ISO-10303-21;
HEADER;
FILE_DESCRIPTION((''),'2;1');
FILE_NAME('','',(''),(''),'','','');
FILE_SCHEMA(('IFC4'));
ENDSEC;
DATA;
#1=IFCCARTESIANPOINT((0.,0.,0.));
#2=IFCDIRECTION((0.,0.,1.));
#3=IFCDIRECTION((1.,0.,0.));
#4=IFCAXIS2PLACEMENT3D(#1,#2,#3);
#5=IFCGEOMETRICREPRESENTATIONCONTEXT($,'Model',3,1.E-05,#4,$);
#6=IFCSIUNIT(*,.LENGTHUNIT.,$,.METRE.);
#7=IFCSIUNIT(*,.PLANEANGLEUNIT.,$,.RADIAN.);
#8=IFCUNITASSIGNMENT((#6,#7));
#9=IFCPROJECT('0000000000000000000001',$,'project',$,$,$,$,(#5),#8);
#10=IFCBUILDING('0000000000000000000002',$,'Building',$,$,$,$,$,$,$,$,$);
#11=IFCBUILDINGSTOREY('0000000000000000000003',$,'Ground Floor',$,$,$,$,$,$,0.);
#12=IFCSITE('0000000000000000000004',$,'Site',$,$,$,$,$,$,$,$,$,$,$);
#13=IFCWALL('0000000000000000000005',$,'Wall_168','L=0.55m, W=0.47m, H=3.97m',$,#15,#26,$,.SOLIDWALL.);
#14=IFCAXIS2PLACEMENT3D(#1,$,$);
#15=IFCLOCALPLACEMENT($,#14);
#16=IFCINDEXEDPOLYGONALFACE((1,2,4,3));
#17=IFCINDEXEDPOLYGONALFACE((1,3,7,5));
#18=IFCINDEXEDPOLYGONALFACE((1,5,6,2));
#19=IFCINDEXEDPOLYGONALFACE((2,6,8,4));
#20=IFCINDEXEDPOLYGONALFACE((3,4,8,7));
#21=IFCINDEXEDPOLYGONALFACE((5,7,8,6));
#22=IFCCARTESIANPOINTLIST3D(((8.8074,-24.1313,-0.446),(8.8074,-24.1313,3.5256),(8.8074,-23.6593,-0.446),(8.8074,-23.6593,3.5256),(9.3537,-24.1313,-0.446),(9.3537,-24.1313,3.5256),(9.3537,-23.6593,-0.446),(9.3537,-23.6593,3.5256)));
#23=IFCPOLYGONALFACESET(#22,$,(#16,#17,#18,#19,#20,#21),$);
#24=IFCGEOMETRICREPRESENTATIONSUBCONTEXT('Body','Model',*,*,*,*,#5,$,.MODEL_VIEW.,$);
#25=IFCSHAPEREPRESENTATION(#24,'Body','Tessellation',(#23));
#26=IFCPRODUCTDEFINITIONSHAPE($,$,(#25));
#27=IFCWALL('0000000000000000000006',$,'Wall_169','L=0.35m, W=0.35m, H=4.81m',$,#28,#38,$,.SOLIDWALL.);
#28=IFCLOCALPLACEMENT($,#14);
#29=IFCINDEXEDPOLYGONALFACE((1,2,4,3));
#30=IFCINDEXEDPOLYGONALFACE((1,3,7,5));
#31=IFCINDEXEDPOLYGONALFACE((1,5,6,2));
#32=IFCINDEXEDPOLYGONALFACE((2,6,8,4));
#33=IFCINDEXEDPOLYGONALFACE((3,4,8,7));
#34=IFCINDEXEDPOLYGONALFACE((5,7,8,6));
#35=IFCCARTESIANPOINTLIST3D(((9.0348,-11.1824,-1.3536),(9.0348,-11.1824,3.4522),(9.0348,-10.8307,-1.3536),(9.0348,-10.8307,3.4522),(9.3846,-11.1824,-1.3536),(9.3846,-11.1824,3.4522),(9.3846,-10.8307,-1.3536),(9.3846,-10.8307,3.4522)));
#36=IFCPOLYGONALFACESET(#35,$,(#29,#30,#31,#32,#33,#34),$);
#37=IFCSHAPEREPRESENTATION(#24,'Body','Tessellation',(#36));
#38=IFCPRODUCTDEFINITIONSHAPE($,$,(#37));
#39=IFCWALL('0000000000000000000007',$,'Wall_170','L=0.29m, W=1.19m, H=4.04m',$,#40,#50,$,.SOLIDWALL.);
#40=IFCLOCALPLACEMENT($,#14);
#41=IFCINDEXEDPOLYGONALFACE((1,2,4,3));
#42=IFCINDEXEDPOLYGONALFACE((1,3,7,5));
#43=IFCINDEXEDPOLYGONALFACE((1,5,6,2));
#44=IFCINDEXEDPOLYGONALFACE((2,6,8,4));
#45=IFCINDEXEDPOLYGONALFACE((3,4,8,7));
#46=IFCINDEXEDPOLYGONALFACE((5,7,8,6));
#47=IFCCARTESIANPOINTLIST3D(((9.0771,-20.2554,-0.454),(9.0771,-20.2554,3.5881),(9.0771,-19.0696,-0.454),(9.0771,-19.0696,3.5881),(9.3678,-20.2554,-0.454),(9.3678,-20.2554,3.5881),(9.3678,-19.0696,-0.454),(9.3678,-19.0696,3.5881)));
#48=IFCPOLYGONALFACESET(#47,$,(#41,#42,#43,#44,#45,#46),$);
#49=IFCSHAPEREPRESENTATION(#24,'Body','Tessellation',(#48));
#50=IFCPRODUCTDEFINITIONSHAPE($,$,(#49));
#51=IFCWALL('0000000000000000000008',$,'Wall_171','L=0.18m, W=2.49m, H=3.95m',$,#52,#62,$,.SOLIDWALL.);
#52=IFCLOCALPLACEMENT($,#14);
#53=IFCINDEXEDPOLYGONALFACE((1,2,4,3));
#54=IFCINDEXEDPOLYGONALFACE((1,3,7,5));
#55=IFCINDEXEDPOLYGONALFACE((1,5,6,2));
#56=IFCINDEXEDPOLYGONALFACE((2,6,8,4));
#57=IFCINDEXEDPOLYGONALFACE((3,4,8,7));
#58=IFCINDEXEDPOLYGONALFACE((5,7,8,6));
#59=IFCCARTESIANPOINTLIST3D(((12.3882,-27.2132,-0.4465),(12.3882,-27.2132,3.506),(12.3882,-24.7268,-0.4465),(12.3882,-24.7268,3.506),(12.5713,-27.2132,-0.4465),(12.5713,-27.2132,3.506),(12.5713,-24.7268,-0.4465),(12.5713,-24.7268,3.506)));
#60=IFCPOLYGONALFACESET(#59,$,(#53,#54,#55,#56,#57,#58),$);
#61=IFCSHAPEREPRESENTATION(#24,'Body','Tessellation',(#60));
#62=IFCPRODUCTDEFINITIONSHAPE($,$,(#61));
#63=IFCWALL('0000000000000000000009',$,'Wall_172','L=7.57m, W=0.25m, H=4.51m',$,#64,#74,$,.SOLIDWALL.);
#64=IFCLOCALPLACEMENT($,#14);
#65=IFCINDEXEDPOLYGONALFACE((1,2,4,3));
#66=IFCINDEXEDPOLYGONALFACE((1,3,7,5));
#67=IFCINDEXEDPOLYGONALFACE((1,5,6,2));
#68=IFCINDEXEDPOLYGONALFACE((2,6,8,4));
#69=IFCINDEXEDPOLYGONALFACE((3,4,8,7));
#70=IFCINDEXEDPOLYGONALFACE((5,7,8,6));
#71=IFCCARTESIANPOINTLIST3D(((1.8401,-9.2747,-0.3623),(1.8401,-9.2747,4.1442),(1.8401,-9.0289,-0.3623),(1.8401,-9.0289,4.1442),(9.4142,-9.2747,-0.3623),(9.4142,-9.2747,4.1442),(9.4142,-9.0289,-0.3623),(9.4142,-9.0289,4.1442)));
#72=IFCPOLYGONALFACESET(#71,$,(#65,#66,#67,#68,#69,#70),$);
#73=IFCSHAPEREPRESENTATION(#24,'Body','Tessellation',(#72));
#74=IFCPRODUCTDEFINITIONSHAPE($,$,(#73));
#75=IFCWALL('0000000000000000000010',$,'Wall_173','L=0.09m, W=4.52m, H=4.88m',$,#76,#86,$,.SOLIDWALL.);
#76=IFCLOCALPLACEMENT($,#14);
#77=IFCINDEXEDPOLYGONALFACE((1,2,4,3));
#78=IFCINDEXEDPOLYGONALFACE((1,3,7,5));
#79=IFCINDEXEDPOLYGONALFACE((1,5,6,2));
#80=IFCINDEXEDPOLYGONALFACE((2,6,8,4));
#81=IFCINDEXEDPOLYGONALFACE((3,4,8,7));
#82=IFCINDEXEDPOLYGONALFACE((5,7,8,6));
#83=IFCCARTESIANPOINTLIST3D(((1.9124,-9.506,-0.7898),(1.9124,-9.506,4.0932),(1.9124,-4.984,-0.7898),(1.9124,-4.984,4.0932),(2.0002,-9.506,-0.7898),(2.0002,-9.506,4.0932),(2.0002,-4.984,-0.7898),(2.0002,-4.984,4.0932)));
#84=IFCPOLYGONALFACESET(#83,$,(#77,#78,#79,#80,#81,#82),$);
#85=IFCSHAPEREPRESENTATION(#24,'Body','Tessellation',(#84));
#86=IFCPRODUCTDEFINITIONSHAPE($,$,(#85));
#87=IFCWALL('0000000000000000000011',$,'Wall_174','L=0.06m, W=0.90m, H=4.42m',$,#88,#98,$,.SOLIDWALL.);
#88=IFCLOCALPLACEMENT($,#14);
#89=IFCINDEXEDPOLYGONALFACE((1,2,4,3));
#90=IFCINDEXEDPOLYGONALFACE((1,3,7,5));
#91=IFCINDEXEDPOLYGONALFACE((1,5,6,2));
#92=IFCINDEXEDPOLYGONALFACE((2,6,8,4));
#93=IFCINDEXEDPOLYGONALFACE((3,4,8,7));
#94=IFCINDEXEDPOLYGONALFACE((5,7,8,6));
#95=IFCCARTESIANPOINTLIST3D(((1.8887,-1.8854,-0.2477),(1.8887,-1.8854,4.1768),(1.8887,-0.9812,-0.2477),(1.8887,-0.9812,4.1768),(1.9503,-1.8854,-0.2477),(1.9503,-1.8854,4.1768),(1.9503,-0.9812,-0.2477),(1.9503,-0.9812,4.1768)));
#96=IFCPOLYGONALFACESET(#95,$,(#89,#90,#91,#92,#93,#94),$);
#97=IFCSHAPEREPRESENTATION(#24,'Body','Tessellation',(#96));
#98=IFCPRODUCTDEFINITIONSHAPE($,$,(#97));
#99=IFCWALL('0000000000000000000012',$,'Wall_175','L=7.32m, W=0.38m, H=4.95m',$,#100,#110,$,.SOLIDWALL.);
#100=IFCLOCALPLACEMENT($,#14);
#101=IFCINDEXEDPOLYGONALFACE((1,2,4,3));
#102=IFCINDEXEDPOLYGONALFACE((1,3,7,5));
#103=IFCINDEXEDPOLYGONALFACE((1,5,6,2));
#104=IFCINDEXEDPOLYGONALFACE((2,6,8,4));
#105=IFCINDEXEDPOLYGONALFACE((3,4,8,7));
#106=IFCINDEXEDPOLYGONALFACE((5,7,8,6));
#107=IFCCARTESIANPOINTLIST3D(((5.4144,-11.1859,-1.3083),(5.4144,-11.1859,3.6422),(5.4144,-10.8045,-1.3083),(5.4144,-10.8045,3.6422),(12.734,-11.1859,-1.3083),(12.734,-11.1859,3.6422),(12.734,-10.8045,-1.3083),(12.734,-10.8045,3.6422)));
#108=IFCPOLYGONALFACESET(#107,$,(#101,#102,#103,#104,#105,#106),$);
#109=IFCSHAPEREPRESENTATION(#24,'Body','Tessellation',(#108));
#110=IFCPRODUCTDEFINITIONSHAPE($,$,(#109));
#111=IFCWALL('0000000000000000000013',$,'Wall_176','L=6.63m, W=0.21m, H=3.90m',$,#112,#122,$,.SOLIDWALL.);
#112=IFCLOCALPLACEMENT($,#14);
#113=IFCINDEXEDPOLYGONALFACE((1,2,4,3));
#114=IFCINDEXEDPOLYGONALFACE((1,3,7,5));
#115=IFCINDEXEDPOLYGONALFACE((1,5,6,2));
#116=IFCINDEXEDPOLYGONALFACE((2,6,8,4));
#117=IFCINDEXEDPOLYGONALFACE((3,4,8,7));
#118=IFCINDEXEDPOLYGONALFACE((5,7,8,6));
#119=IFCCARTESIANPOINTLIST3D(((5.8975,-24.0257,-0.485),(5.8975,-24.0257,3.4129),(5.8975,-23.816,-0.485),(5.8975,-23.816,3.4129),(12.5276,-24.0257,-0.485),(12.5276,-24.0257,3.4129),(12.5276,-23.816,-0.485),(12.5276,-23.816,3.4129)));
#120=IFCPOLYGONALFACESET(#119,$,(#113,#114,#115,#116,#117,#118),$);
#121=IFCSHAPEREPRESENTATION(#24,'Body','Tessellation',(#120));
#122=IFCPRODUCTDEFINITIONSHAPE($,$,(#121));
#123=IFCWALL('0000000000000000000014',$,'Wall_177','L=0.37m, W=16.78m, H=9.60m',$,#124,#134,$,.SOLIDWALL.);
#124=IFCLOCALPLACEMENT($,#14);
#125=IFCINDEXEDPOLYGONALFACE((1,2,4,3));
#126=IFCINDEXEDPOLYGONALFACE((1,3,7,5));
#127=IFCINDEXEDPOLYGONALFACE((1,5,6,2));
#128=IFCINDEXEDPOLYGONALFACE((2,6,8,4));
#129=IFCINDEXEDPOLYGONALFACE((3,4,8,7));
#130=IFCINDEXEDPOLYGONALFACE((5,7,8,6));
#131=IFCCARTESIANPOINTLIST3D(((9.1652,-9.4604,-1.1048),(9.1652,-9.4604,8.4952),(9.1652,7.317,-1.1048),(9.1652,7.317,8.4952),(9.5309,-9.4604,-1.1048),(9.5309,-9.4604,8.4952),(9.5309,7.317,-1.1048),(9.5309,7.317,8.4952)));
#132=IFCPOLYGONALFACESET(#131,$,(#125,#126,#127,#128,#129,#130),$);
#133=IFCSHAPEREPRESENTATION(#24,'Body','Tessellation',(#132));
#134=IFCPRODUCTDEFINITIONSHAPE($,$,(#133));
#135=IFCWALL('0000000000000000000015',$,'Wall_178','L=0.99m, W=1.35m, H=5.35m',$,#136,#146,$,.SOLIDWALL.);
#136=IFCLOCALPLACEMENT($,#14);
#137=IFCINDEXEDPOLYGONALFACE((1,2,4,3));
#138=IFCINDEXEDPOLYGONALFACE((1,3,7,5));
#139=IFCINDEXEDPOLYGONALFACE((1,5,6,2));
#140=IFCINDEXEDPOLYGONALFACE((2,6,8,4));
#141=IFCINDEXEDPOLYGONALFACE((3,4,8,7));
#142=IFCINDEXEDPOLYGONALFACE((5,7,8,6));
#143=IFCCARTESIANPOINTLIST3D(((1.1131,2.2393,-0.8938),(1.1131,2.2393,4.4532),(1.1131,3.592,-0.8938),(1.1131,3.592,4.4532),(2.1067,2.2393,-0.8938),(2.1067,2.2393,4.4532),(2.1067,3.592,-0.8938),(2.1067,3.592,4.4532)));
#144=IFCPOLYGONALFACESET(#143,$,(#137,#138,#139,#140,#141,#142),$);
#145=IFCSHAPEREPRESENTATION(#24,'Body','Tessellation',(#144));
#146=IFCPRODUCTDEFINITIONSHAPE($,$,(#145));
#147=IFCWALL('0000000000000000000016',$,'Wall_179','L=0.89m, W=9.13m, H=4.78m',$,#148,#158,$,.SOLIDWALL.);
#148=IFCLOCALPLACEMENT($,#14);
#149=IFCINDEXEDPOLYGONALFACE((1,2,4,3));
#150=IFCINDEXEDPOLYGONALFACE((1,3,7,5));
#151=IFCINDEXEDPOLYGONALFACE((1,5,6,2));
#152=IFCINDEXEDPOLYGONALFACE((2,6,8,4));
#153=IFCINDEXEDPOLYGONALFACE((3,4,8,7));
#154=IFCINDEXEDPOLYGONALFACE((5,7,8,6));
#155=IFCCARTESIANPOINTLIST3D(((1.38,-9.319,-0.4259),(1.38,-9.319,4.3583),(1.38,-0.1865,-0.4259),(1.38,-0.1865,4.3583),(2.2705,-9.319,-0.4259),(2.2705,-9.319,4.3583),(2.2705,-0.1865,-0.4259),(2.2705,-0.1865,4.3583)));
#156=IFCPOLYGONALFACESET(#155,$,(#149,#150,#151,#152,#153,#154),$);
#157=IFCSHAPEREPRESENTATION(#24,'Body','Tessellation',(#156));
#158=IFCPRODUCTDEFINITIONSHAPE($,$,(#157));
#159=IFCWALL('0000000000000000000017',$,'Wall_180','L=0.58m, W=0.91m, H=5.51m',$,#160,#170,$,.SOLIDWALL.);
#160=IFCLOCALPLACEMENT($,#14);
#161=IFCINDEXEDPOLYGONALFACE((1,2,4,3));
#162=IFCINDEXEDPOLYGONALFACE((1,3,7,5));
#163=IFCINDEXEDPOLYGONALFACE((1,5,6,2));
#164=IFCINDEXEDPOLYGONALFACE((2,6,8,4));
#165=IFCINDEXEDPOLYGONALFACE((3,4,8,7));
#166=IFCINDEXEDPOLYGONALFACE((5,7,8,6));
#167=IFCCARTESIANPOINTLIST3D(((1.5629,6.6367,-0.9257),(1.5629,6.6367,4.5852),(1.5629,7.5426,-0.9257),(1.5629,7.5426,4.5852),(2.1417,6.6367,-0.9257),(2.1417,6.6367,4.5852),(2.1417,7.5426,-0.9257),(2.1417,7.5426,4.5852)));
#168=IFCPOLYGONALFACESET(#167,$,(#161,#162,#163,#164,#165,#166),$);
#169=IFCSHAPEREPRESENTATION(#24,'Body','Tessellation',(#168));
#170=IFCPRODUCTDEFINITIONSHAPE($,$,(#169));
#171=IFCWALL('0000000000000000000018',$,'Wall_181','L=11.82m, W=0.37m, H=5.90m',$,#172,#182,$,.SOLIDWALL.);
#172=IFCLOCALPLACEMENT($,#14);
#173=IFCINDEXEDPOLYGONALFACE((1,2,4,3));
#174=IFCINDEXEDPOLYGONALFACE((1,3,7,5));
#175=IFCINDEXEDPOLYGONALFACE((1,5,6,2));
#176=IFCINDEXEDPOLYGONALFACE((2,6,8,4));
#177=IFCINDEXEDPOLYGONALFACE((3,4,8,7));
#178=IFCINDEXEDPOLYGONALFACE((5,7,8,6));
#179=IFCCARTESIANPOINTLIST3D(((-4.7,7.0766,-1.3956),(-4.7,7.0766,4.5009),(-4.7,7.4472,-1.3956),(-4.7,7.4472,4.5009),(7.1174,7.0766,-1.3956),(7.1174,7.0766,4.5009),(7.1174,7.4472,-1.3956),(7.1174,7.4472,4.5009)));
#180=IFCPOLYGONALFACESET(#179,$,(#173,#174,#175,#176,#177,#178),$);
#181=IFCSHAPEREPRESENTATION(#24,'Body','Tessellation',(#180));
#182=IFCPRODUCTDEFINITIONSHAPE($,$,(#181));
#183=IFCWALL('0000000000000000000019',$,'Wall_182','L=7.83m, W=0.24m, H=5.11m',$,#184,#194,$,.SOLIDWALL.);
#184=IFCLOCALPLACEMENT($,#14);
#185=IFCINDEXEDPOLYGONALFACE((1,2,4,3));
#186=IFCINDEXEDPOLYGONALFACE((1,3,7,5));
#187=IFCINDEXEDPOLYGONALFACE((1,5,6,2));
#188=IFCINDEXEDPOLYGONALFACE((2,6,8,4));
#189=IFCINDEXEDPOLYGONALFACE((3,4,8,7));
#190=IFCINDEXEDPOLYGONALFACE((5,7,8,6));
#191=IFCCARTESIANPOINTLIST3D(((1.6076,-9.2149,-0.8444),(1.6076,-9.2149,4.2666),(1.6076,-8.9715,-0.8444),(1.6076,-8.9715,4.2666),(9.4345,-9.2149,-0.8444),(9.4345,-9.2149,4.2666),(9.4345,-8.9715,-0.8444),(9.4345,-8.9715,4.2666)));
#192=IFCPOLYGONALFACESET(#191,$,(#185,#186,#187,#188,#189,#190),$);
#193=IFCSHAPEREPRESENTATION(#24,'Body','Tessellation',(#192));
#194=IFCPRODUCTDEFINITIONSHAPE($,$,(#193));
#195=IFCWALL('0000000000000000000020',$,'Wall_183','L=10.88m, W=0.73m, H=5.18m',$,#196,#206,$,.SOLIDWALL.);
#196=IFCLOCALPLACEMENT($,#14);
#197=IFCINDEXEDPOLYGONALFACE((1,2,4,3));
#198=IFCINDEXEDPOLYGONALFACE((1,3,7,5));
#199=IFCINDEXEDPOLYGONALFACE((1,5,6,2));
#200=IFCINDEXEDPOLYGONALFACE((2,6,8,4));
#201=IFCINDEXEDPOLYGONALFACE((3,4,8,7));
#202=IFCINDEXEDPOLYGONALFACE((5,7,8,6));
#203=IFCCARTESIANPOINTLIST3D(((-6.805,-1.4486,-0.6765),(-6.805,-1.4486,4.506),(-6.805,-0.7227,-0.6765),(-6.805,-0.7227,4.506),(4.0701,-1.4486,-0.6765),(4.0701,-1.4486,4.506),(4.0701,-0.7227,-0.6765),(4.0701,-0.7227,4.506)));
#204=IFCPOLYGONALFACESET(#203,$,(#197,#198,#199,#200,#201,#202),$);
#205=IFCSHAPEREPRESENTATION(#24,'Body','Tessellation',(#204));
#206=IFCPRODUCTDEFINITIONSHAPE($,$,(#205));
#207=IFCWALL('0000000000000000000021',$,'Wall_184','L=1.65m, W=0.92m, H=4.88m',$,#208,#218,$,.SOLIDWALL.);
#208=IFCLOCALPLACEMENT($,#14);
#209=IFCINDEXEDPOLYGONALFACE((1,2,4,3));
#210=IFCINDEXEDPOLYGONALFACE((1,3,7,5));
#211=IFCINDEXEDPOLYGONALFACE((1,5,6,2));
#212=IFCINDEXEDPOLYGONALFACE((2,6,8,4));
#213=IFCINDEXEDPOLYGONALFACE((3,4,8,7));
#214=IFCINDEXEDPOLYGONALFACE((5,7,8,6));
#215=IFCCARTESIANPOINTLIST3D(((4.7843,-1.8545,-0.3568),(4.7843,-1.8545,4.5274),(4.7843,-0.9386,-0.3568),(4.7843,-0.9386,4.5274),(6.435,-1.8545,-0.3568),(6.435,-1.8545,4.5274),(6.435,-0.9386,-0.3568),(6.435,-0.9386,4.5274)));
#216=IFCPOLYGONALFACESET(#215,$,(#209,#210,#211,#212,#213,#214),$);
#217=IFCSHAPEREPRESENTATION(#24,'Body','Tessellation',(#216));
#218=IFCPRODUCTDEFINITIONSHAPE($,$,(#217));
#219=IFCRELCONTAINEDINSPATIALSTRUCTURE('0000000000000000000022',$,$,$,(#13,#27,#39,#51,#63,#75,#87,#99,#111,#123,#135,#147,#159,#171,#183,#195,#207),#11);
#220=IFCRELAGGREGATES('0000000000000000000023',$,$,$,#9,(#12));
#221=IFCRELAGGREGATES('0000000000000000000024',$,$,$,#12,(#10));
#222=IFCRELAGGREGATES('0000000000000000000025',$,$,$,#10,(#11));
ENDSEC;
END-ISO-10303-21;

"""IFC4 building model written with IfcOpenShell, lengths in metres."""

from ifc_helpers import new_model, si_unit, frame, origin_with_axes, origin_2d, context, subcontext, project, spatial, rectangle, extrude, element, save


model = new_model("IFC4")

# Units and contexts
model_context = context("Model", 3, precision=1e-05, world=origin_with_axes())
body_context = subcontext(model_context, "Body", "Model", "MODEL_VIEW")
ifc_project = project(units=[si_unit("LENGTHUNIT", "METRE"), si_unit("PLANEANGLEUNIT", "RADIAN")], contexts=[model_context])

# Site, building, storey
site = spatial("IfcSite", under=ifc_project, Name="Site")
building = spatial("IfcBuilding", under=site, Name="Building")
storey = spatial("IfcBuildingStorey", under=building, Name="Ground Floor", Elevation=0.0)

# Walls
element("IfcWall", 1, inside=storey, Name="Wall_168", Description="L=0.55m, W=0.47m, H=3.97m", PredefinedType="SOLIDWALL", context=body_context, shape_type="SweptSolid", body=[
    extrude(rectangle(XDim=0.5463, YDim=0.472, at=origin_2d()), frame((9.0806, -23.8953, -0.446), z_axis=(0.0, 0.0, 1.0), x_axis=(1.0, 0.0, 0.0)), (0.0, 0.0, 1.0), 3.9716),
])
element("IfcWall", 2, inside=storey, Name="Wall_169", Description="L=0.35m, W=0.35m, H=4.81m", PredefinedType="SOLIDWALL", context=body_context, shape_type="SweptSolid", body=[
    extrude(rectangle(XDim=0.3497, YDim=0.3517, at=origin_2d()), frame((9.2097, -11.0066, -1.3536), z_axis=(0.0, 0.0, 1.0), x_axis=(1.0, 0.0, 0.0)), (0.0, 0.0, 1.0), 4.8058),
])
element("IfcWall", 3, inside=storey, Name="Wall_170", Description="L=0.29m, W=1.19m, H=4.04m", PredefinedType="SOLIDWALL", context=body_context, shape_type="SweptSolid", body=[
    extrude(rectangle(XDim=0.2907, YDim=1.1858, at=origin_2d()), frame((9.2224, -19.6625, -0.454), z_axis=(0.0, 0.0, 1.0), x_axis=(1.0, 0.0, 0.0)), (0.0, 0.0, 1.0), 4.0421),
])
element("IfcWall", 4, inside=storey, Name="Wall_171", Description="L=0.18m, W=2.49m, H=3.95m", PredefinedType="SOLIDWALL", context=body_context, shape_type="SweptSolid", body=[
    extrude(rectangle(XDim=0.1831, YDim=2.4865, at=origin_2d()), frame((12.4797, -25.97, -0.4465), z_axis=(0.0, 0.0, 1.0), x_axis=(1.0, 0.0, 0.0)), (0.0, 0.0, 1.0), 3.9525),
])
element("IfcWall", 5, inside=storey, Name="Wall_172", Description="L=7.57m, W=0.25m, H=4.51m", PredefinedType="SOLIDWALL", context=body_context, shape_type="SweptSolid", body=[
    extrude(rectangle(XDim=7.574, YDim=0.2458, at=origin_2d()), frame((5.6272, -9.1518, -0.3623), z_axis=(0.0, 0.0, 1.0), x_axis=(1.0, 0.0, 0.0)), (0.0, 0.0, 1.0), 4.5066),
])
element("IfcWall", 6, inside=storey, Name="Wall_173", Description="L=0.09m, W=4.52m, H=4.88m", PredefinedType="SOLIDWALL", context=body_context, shape_type="SweptSolid", body=[
    extrude(rectangle(XDim=0.0879, YDim=4.522, at=origin_2d()), frame((1.9563, -7.245, -0.7898), z_axis=(0.0, 0.0, 1.0), x_axis=(1.0, 0.0, 0.0)), (0.0, 0.0, 1.0), 4.883),
])
element("IfcWall", 7, inside=storey, Name="Wall_174", Description="L=0.06m, W=0.90m, H=4.42m", PredefinedType="SOLIDWALL", context=body_context, shape_type="SweptSolid", body=[
    extrude(rectangle(XDim=0.0616, YDim=0.9042, at=origin_2d()), frame((1.9195, -1.4333, -0.2477), z_axis=(0.0, 0.0, 1.0), x_axis=(1.0, 0.0, 0.0)), (0.0, 0.0, 1.0), 4.4245),
])
element("IfcWall", 8, inside=storey, Name="Wall_175", Description="L=7.32m, W=0.38m, H=4.95m", PredefinedType="SOLIDWALL", context=body_context, shape_type="SweptSolid", body=[
    extrude(rectangle(XDim=7.3196, YDim=0.3814, at=origin_2d()), frame((9.0742, -10.9952, -1.3083), z_axis=(0.0, 0.0, 1.0), x_axis=(1.0, 0.0, 0.0)), (0.0, 0.0, 1.0), 4.9505),
])
element("IfcWall", 9, inside=storey, Name="Wall_176", Description="L=6.63m, W=0.21m, H=3.90m", PredefinedType="SOLIDWALL", context=body_context, shape_type="SweptSolid", body=[
    extrude(rectangle(XDim=6.6301, YDim=0.2098, at=origin_2d()), frame((9.2125, -23.9209, -0.485), z_axis=(0.0, 0.0, 1.0), x_axis=(1.0, 0.0, 0.0)), (0.0, 0.0, 1.0), 3.8979),
])
element("IfcWall", 10, inside=storey, Name="Wall_177", Description="L=0.37m, W=16.78m, H=9.60m", PredefinedType="SOLIDWALL", context=body_context, shape_type="SweptSolid", body=[
    extrude(rectangle(XDim=0.3657, YDim=16.7774, at=origin_2d()), frame((9.348, -1.0717, -1.1048), z_axis=(0.0, 0.0, 1.0), x_axis=(1.0, 0.0, 0.0)), (0.0, 0.0, 1.0), 9.6),
])
element("IfcWall", 11, inside=storey, Name="Wall_178", Description="L=0.99m, W=1.35m, H=5.35m", PredefinedType="SOLIDWALL", context=body_context, shape_type="SweptSolid", body=[
    extrude(rectangle(XDim=0.9935, YDim=1.3527, at=origin_2d()), frame((1.6099, 2.9157, -0.8938), z_axis=(0.0, 0.0, 1.0), x_axis=(1.0, 0.0, 0.0)), (0.0, 0.0, 1.0), 5.347),
])
element("IfcWall", 12, inside=storey, Name="Wall_179", Description="L=0.89m, W=9.13m, H=4.78m", PredefinedType="SOLIDWALL", context=body_context, shape_type="SweptSolid", body=[
    extrude(rectangle(XDim=0.8905, YDim=9.1325, at=origin_2d()), frame((1.8252, -4.7527, -0.4259), z_axis=(0.0, 0.0, 1.0), x_axis=(1.0, 0.0, 0.0)), (0.0, 0.0, 1.0), 4.7842),
])
element("IfcWall", 13, inside=storey, Name="Wall_180", Description="L=0.58m, W=0.91m, H=5.51m", PredefinedType="SOLIDWALL", context=body_context, shape_type="SweptSolid", body=[
    extrude(rectangle(XDim=0.5788, YDim=0.9059, at=origin_2d()), frame((1.8523, 7.0896, -0.9257), z_axis=(0.0, 0.0, 1.0), x_axis=(1.0, 0.0, 0.0)), (0.0, 0.0, 1.0), 5.5109),
])
element("IfcWall", 14, inside=storey, Name="Wall_181", Description="L=11.82m, W=0.37m, H=5.90m", PredefinedType="SOLIDWALL", context=body_context, shape_type="SweptSolid", body=[
    extrude(rectangle(XDim=11.8173, YDim=0.3706, at=origin_2d()), frame((1.2087, 7.2619, -1.3956), z_axis=(0.0, 0.0, 1.0), x_axis=(1.0, 0.0, 0.0)), (0.0, 0.0, 1.0), 5.8965),
])
element("IfcWall", 15, inside=storey, Name="Wall_182", Description="L=7.83m, W=0.24m, H=5.11m", PredefinedType="SOLIDWALL", context=body_context, shape_type="SweptSolid", body=[
    extrude(rectangle(XDim=7.8269, YDim=0.2435, at=origin_2d()), frame((5.521, -9.0932, -0.8444), z_axis=(0.0, 0.0, 1.0), x_axis=(1.0, 0.0, 0.0)), (0.0, 0.0, 1.0), 5.111),
])
element("IfcWall", 16, inside=storey, Name="Wall_183", Description="L=10.88m, W=0.73m, H=5.18m", PredefinedType="SOLIDWALL", context=body_context, shape_type="SweptSolid", body=[
    extrude(rectangle(XDim=10.8751, YDim=0.726, at=origin_2d()), frame((-1.3675, -1.0857, -0.6765), z_axis=(0.0, 0.0, 1.0), x_axis=(1.0, 0.0, 0.0)), (0.0, 0.0, 1.0), 5.1825),
])
element("IfcWall", 17, inside=storey, Name="Wall_184", Description="L=1.65m, W=0.92m, H=4.88m", PredefinedType="SOLIDWALL", context=body_context, shape_type="SweptSolid", body=[
    extrude(rectangle(XDim=1.6507, YDim=0.9159, at=origin_2d()), frame((5.6097, -1.3965, -0.3568), z_axis=(0.0, 0.0, 1.0), x_axis=(1.0, 0.0, 0.0)), (0.0, 0.0, 1.0), 4.8842),
])

save(model, "model.ifc")
